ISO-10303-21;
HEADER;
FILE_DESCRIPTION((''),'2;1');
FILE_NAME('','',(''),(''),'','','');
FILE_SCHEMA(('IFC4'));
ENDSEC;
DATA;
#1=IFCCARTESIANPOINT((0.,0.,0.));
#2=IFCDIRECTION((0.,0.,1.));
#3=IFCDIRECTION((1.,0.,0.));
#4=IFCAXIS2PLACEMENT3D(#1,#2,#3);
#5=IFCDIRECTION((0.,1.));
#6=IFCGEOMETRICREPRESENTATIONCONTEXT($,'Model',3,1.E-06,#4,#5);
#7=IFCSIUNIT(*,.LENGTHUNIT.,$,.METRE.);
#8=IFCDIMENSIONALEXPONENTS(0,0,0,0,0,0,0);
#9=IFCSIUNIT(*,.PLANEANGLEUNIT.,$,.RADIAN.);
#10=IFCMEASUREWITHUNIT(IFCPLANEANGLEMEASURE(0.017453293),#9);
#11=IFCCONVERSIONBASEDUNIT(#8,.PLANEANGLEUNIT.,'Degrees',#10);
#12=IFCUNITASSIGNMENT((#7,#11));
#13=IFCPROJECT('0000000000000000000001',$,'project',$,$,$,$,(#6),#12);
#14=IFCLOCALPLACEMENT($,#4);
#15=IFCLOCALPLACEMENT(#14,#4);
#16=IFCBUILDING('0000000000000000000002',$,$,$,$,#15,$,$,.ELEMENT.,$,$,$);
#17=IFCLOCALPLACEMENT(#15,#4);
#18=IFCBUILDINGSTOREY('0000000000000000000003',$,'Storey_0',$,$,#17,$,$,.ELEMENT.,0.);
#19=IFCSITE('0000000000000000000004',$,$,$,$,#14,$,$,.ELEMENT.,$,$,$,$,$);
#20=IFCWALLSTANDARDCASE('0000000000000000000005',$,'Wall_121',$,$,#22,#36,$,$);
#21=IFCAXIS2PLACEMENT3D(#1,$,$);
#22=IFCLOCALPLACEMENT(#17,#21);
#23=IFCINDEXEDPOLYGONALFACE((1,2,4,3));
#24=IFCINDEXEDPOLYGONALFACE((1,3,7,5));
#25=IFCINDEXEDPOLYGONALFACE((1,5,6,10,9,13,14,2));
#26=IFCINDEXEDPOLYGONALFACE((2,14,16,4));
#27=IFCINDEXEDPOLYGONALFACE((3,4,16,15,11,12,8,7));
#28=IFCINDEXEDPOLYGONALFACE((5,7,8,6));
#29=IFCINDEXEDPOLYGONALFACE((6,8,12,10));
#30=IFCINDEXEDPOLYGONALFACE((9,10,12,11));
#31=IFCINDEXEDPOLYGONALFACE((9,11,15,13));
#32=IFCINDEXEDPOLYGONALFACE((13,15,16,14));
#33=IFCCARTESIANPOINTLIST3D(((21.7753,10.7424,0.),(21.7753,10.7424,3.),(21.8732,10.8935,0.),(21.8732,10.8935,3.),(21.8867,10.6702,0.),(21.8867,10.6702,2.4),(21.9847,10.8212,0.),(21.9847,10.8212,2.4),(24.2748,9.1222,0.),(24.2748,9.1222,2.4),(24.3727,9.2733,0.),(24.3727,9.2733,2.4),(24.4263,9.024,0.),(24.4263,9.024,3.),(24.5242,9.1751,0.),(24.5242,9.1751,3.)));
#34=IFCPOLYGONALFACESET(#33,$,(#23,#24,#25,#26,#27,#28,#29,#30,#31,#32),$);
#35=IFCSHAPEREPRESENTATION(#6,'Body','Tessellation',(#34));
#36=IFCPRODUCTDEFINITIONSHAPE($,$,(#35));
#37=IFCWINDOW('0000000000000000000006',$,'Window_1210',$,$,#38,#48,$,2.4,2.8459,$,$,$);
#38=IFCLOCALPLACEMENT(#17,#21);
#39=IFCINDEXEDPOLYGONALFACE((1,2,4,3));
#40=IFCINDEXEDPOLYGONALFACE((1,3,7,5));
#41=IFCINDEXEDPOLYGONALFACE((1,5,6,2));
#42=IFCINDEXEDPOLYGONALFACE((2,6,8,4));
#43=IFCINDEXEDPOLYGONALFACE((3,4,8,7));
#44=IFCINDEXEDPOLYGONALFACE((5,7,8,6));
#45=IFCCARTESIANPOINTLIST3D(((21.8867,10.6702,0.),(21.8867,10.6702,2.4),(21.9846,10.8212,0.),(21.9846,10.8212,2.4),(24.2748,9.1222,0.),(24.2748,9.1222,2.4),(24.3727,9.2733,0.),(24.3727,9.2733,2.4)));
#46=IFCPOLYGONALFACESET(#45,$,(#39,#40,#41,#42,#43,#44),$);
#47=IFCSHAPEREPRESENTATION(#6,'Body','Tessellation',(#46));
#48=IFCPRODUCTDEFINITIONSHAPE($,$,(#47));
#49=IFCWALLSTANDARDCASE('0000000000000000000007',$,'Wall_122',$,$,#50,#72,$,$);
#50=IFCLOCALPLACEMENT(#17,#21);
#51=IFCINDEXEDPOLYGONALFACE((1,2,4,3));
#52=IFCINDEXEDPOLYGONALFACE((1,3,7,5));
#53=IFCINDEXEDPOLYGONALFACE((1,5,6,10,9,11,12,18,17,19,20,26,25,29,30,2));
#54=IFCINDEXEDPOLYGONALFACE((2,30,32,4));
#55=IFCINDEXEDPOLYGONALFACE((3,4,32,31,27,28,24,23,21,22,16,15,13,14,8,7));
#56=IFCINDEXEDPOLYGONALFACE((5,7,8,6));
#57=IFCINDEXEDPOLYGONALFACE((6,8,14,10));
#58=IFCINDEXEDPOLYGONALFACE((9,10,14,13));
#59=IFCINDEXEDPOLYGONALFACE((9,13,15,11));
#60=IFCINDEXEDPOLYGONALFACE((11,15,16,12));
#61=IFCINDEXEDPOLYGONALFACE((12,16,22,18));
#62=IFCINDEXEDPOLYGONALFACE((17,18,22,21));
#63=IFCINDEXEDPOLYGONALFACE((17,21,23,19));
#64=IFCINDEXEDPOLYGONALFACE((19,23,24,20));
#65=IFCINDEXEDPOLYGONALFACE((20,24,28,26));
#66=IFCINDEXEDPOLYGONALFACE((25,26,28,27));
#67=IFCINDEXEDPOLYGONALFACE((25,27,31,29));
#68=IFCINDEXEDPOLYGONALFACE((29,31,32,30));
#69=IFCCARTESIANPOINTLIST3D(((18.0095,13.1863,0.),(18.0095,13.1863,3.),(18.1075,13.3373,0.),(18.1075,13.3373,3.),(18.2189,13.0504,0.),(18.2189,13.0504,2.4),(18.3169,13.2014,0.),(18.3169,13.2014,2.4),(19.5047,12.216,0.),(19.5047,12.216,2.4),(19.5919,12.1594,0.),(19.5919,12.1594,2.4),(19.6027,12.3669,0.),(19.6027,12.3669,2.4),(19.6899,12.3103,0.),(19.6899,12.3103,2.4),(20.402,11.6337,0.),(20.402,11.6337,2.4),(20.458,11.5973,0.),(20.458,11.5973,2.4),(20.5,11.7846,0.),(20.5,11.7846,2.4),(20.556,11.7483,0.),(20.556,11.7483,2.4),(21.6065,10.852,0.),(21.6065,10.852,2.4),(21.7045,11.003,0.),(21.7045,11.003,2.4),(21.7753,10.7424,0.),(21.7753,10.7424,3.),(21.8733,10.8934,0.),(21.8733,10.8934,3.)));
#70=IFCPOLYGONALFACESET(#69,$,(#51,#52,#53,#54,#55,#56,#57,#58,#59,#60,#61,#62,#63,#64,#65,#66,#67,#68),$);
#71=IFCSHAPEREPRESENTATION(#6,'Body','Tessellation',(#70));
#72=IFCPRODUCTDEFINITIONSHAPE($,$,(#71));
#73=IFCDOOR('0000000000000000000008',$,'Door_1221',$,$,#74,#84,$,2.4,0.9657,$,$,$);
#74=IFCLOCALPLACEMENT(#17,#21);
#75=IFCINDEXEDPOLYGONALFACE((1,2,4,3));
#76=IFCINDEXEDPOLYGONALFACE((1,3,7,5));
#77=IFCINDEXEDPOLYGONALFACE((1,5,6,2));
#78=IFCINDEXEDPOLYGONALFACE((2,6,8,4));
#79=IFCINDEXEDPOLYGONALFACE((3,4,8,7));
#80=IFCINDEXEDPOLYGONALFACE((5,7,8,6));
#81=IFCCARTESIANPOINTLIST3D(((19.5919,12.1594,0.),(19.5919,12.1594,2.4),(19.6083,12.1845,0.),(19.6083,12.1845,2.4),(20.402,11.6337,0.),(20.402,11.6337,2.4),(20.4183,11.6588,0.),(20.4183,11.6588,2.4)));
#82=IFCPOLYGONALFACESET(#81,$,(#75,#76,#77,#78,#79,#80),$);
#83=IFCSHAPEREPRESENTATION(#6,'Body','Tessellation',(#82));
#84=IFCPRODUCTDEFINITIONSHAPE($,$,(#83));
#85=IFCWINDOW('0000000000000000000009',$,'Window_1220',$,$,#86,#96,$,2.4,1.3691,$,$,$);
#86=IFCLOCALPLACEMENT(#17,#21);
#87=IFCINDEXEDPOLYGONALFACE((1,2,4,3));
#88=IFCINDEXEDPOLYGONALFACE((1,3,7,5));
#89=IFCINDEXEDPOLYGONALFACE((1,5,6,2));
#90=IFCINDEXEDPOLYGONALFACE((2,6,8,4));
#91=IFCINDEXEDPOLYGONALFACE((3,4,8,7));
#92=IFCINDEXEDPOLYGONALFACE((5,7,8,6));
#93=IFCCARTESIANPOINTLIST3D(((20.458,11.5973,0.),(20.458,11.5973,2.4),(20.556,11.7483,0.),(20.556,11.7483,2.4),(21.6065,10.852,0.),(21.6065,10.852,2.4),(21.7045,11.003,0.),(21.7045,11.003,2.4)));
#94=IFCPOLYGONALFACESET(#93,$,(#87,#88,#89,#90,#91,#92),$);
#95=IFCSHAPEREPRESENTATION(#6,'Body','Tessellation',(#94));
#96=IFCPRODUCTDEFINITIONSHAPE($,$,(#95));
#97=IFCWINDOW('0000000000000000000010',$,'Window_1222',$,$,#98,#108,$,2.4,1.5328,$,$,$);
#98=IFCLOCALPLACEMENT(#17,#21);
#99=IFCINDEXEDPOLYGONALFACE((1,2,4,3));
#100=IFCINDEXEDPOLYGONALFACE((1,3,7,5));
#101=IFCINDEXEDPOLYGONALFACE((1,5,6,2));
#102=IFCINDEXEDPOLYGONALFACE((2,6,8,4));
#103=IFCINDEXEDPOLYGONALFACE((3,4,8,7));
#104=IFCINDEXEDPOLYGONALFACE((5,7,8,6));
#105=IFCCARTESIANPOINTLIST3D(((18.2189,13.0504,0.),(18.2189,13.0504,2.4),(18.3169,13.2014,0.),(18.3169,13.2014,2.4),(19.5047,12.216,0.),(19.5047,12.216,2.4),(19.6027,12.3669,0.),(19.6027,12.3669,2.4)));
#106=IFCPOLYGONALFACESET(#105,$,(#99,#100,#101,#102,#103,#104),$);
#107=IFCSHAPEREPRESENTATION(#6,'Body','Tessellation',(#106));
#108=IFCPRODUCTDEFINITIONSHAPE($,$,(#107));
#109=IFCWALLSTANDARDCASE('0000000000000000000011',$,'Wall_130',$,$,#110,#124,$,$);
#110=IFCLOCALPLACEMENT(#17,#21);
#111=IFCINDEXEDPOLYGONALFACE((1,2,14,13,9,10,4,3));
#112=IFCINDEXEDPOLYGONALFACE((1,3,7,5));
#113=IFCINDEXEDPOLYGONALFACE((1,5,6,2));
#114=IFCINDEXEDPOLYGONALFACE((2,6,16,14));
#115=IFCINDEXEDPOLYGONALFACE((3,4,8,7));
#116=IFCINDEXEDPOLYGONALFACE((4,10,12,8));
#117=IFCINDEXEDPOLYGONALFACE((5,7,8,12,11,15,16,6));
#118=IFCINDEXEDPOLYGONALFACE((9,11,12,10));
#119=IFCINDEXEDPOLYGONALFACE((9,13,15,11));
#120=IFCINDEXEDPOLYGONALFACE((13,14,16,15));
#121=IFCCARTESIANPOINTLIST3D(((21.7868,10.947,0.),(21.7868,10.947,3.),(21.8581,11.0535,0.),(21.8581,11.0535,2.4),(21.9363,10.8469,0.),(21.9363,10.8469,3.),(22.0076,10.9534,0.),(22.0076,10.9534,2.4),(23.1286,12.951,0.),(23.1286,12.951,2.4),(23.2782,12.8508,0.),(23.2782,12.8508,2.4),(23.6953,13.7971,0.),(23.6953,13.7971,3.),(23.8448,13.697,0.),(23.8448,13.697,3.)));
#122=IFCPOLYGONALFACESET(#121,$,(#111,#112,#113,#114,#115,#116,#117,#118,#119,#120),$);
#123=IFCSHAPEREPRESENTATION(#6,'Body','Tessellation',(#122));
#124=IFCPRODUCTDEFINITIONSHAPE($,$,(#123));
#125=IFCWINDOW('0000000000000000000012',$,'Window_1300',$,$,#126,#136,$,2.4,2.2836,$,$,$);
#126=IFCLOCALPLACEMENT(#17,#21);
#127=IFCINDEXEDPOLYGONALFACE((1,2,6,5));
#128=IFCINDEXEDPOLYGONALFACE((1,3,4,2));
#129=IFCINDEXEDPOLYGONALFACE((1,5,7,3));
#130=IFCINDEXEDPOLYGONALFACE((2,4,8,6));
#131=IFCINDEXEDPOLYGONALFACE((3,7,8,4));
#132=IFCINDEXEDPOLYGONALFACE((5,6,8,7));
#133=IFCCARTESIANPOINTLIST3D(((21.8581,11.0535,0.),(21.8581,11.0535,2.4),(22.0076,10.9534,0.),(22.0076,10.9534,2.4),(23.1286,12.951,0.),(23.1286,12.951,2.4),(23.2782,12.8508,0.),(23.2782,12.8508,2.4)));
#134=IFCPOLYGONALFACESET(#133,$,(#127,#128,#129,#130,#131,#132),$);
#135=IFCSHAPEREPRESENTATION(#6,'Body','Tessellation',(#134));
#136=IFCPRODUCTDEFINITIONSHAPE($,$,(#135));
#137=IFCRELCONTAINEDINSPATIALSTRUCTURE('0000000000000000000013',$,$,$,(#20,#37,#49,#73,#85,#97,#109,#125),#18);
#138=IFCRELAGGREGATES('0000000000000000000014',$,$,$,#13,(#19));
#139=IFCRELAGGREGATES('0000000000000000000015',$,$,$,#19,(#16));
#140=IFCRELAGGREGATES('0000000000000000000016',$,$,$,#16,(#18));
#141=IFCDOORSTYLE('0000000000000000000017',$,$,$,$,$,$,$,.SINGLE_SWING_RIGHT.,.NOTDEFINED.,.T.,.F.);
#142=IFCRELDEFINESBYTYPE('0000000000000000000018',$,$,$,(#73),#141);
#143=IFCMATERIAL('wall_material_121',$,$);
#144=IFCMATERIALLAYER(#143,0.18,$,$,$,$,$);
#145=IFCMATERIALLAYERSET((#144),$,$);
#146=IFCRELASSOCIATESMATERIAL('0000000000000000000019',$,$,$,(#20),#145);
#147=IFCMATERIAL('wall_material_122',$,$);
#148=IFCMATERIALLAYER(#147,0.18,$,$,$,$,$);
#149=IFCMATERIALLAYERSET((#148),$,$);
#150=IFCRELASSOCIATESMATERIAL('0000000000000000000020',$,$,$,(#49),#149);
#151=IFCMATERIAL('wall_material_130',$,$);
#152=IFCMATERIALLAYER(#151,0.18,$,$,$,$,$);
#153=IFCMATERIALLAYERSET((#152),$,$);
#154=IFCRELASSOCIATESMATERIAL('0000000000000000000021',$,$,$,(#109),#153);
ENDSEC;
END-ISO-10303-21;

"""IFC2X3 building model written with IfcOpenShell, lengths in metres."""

from ifc_helpers import new_model, entity, si_unit, converted_unit, direction, frame, frame_2d, origin_with_axes, place, context, project, spatial, polyline, rectangle, outline, extrude, material, layer, layer_set, layer_usage, type_object, element, fill, save


model = new_model("IFC2X3")

# Units and contexts
model_context = context("Model", 3, precision=1e-06, world=origin_with_axes(), true_north=direction((0.0, 1.0)))
ifc_project = project(units=[si_unit("LENGTHUNIT", "METRE"), converted_unit("PLANEANGLEUNIT", "Degrees", entity("IfcPlaneAngleMeasure", 0.017453293), si_unit("PLANEANGLEUNIT", "RADIAN"), dimensions=[0, 0, 0, 0, 0, 0, 0])], contexts=[model_context])

# Site, building, storey
site_placement = place(None, origin_with_axes())
site = spatial("IfcSite", under=ifc_project, at=site_placement, CompositionType="ELEMENT")
building_placement = place(site_placement, origin_with_axes())
building = spatial("IfcBuilding", under=site, at=building_placement, CompositionType="ELEMENT")
storey_placement = place(building_placement, origin_with_axes())
storey = spatial("IfcBuildingStorey", under=building, at=storey_placement, Name="Storey_0", CompositionType="ELEMENT", Elevation=0.0)

# Wall, opening, window
ifc_material_1 = material(Name="wall_material_121")
ifc_layer_1 = layer(ifc_material_1, 0.18)
ifc_layer_set_1 = layer_set([ifc_layer_1])
ifc_layer_usage_1 = layer_usage(ifc_layer_set_1, "AXIS2", "NEGATIVE", 0.0)
wall_1_placement = place(storey_placement, frame((24.4263, 9.024, 0.0), z_axis=(0.0, 0.0, 1.0), x_axis=(-0.839124, 0.54394, 0.0)))
wall_1 = element("IfcWallStandardCase", 1, at=wall_1_placement, inside=storey, material=ifc_layer_usage_1, Name="Wall_121", context=model_context, shape_type="SweptSolid", body=[
    extrude(outline(polyline([(0.0, 0.0), (3.1592, 0.0), (3.1592, -0.18), (0.0, -0.18), (0.0, 0.0)])), origin_with_axes(), (0.0, 0.0, 1.0), 3.0),
])
opening_1_placement = place(wall_1_placement, frame((0.1806, 0.0, 0.0), z_axis=(0.0, 0.0, 1.0), x_axis=(1.0, 0.0, 0.0)))
opening_1 = element("IfcOpeningElement", 2, at=opening_1_placement, cuts=wall_1, context=model_context, shape_type="SweptSolid", body=[
    extrude(rectangle(XDim=2.8459, YDim=2.4, at=frame_2d((1.2, -1.4229), x_axis=(0.0, 1.0))), frame((0.0, 0.01, 0.0), z_axis=(0.0, -1.0, 0.0), x_axis=(0.0, 0.0, 1.0)), (0.0, 0.0, 1.0), 0.2),
])
window_1_placement = place(storey_placement, origin_with_axes())
window_1 = element("IfcWindow", 3, at=window_1_placement, inside=storey, Name="Window_1210", OverallHeight=2.4, OverallWidth=2.8459, context=model_context, shape_type="SweptSolid", body=[
    extrude(outline(polyline([(24.2748, 9.1222), (21.8867, 10.6702), (21.9846, 10.8212), (24.3727, 9.2733), (24.2748, 9.1222)])), origin_with_axes(), (0.0, 0.0, 1.0), 2.4),
])
fill(opening_1, window_1)

# Wall, openings, door, windows
ifc_material_2 = material(Name="wall_material_122")
ifc_layer_2 = layer(ifc_material_2, 0.18)
ifc_layer_set_2 = layer_set([ifc_layer_2])
ifc_layer_usage_2 = layer_usage(ifc_layer_set_2, "AXIS2", "NEGATIVE", 0.0)
wall_2_placement = place(storey_placement, frame((21.7753, 10.7424, 0.0), z_axis=(0.0, 0.0, 1.0), x_axis=(-0.838843, 0.544373, 0.0)))
wall_2 = element("IfcWallStandardCase", 4, at=wall_2_placement, inside=storey, material=ifc_layer_usage_2, Name="Wall_122", context=model_context, shape_type="SweptSolid", body=[
    extrude(outline(polyline([(0.0, 0.0), (4.4893, 0.0), (4.4893, -0.18), (0.0, -0.18), (0.0, 0.0)])), origin_with_axes(), (0.0, 0.0, 1.0), 3.0),
])
opening_2_placement = place(wall_2_placement, frame((0.2013, 0.0, 0.0), z_axis=(0.0, 0.0, 1.0), x_axis=(1.0, 0.0, 0.0)))
opening_2 = element("IfcOpeningElement", 5, at=opening_2_placement, cuts=wall_2, context=model_context, shape_type="SweptSolid", body=[
    extrude(rectangle(XDim=1.3691, YDim=2.4, at=frame_2d((1.2, -0.6845), x_axis=(0.0, 1.0))), frame((0.0, 0.01, 0.0), z_axis=(0.0, -1.0, 0.0), x_axis=(0.0, 0.0, 1.0)), (0.0, 0.0, 1.0), 0.2),
])
opening_3_placement = place(wall_2_placement, frame((1.6371, 0.0, 0.0), z_axis=(0.0, 0.0, 1.0), x_axis=(1.0, 0.0, 0.0)))
opening_3 = element("IfcOpeningElement", 6, at=opening_3_placement, cuts=wall_2, context=model_context, shape_type="SweptSolid", body=[
    extrude(rectangle(XDim=0.9657, YDim=2.4, at=frame_2d((1.2, -0.4829), x_axis=(0.0, 1.0))), frame((0.0, 0.01, 0.0), z_axis=(0.0, -1.0, 0.0), x_axis=(0.0, 0.0, 1.0)), (0.0, 0.0, 1.0), 0.2),
])
opening_4_placement = place(wall_2_placement, frame((2.7068, 0.0, 0.0), z_axis=(0.0, 0.0, 1.0), x_axis=(1.0, 0.0, 0.0)))
opening_4 = element("IfcOpeningElement", 7, at=opening_4_placement, cuts=wall_2, context=model_context, shape_type="SweptSolid", body=[
    extrude(rectangle(XDim=1.5328, YDim=2.4, at=frame_2d((1.2, -0.7664), x_axis=(0.0, 1.0))), frame((0.0, 0.01, 0.0), z_axis=(0.0, -1.0, 0.0), x_axis=(0.0, 0.0, 1.0)), (0.0, 0.0, 1.0), 0.2),
])
door_style_1 = type_object("IfcDoorStyle", ConstructionType="NOTDEFINED", OperationType="SINGLE_SWING_RIGHT", ParameterTakesPrecedence=True, Sizeable=False)
door_1_placement = place(storey_placement, origin_with_axes())
door_1 = element("IfcDoor", 8, at=door_1_placement, inside=storey, type_object=door_style_1, Name="Door_1221", OverallHeight=2.4, OverallWidth=0.9657, context=model_context, shape_type="SweptSolid", body=[
    extrude(outline(polyline([(20.402, 11.6337), (19.5919, 12.1594), (19.6083, 12.1845), (20.4183, 11.6588), (20.402, 11.6337)])), origin_with_axes(), (0.0, 0.0, 1.0), 2.4),
])
fill(opening_3, door_1)
window_2_placement = place(storey_placement, origin_with_axes())
window_2 = element("IfcWindow", 9, at=window_2_placement, inside=storey, Name="Window_1220", OverallHeight=2.4, OverallWidth=1.3691, context=model_context, shape_type="SweptSolid", body=[
    extrude(outline(polyline([(21.6065, 10.852), (20.458, 11.5973), (20.556, 11.7483), (21.7045, 11.003), (21.6065, 10.852)])), origin_with_axes(), (0.0, 0.0, 1.0), 2.4),
])
fill(opening_2, window_2)
window_3_placement = place(storey_placement, origin_with_axes())
window_3 = element("IfcWindow", 10, at=window_3_placement, inside=storey, Name="Window_1222", OverallHeight=2.4, OverallWidth=1.5328, context=model_context, shape_type="SweptSolid", body=[
    extrude(outline(polyline([(19.5047, 12.216), (18.2189, 13.0504), (18.3169, 13.2014), (19.6027, 12.3669), (19.5047, 12.216)])), origin_with_axes(), (0.0, 0.0, 1.0), 2.4),
])
fill(opening_4, window_3)

# Wall, opening, window
ifc_material_3 = material(Name="wall_material_130")
ifc_layer_3 = layer(ifc_material_3, 0.18)
ifc_layer_set_3 = layer_set([ifc_layer_3])
ifc_layer_usage_3 = layer_usage(ifc_layer_set_3, "AXIS2", "NEGATIVE", 0.0)
wall_3_placement = place(storey_placement, frame((21.7868, 10.947, 0.0), z_axis=(0.0, 0.0, 1.0), x_axis=(0.556399, 0.830915, 0.0)))
wall_3 = element("IfcWallStandardCase", 11, at=wall_3_placement, inside=storey, material=ifc_layer_usage_3, Name="Wall_130", context=model_context, shape_type="SweptSolid", body=[
    extrude(outline(polyline([(0.0, 0.0), (3.4301, 0.0), (3.4301, -0.18), (0.0, -0.18), (0.0, 0.0)])), origin_with_axes(), (0.0, 0.0, 1.0), 3.0),
])
opening_5_placement = place(wall_3_placement, frame((0.1282, 0.0, 0.0), z_axis=(0.0, 0.0, 1.0), x_axis=(1.0, 0.0, 0.0)))
opening_5 = element("IfcOpeningElement", 12, at=opening_5_placement, cuts=wall_3, context=model_context, shape_type="SweptSolid", body=[
    extrude(rectangle(XDim=2.2836, YDim=2.4, at=frame_2d((1.2, -1.1418), x_axis=(0.0, 1.0))), frame((0.0, 0.01, 0.0), z_axis=(0.0, -1.0, 0.0), x_axis=(0.0, 0.0, 1.0)), (0.0, 0.0, 1.0), 0.2),
])
window_4_placement = place(storey_placement, origin_with_axes())
window_4 = element("IfcWindow", 13, at=window_4_placement, inside=storey, Name="Window_1300", OverallHeight=2.4, OverallWidth=2.2836, context=model_context, shape_type="SweptSolid", body=[
    extrude(outline(polyline([(21.8581, 11.0535), (23.1286, 12.951), (23.2782, 12.8508), (22.0076, 10.9534), (21.8581, 11.0535)])), origin_with_axes(), (0.0, 0.0, 1.0), 2.4),
])
fill(opening_5, window_4)

save(model, "model.ifc")
